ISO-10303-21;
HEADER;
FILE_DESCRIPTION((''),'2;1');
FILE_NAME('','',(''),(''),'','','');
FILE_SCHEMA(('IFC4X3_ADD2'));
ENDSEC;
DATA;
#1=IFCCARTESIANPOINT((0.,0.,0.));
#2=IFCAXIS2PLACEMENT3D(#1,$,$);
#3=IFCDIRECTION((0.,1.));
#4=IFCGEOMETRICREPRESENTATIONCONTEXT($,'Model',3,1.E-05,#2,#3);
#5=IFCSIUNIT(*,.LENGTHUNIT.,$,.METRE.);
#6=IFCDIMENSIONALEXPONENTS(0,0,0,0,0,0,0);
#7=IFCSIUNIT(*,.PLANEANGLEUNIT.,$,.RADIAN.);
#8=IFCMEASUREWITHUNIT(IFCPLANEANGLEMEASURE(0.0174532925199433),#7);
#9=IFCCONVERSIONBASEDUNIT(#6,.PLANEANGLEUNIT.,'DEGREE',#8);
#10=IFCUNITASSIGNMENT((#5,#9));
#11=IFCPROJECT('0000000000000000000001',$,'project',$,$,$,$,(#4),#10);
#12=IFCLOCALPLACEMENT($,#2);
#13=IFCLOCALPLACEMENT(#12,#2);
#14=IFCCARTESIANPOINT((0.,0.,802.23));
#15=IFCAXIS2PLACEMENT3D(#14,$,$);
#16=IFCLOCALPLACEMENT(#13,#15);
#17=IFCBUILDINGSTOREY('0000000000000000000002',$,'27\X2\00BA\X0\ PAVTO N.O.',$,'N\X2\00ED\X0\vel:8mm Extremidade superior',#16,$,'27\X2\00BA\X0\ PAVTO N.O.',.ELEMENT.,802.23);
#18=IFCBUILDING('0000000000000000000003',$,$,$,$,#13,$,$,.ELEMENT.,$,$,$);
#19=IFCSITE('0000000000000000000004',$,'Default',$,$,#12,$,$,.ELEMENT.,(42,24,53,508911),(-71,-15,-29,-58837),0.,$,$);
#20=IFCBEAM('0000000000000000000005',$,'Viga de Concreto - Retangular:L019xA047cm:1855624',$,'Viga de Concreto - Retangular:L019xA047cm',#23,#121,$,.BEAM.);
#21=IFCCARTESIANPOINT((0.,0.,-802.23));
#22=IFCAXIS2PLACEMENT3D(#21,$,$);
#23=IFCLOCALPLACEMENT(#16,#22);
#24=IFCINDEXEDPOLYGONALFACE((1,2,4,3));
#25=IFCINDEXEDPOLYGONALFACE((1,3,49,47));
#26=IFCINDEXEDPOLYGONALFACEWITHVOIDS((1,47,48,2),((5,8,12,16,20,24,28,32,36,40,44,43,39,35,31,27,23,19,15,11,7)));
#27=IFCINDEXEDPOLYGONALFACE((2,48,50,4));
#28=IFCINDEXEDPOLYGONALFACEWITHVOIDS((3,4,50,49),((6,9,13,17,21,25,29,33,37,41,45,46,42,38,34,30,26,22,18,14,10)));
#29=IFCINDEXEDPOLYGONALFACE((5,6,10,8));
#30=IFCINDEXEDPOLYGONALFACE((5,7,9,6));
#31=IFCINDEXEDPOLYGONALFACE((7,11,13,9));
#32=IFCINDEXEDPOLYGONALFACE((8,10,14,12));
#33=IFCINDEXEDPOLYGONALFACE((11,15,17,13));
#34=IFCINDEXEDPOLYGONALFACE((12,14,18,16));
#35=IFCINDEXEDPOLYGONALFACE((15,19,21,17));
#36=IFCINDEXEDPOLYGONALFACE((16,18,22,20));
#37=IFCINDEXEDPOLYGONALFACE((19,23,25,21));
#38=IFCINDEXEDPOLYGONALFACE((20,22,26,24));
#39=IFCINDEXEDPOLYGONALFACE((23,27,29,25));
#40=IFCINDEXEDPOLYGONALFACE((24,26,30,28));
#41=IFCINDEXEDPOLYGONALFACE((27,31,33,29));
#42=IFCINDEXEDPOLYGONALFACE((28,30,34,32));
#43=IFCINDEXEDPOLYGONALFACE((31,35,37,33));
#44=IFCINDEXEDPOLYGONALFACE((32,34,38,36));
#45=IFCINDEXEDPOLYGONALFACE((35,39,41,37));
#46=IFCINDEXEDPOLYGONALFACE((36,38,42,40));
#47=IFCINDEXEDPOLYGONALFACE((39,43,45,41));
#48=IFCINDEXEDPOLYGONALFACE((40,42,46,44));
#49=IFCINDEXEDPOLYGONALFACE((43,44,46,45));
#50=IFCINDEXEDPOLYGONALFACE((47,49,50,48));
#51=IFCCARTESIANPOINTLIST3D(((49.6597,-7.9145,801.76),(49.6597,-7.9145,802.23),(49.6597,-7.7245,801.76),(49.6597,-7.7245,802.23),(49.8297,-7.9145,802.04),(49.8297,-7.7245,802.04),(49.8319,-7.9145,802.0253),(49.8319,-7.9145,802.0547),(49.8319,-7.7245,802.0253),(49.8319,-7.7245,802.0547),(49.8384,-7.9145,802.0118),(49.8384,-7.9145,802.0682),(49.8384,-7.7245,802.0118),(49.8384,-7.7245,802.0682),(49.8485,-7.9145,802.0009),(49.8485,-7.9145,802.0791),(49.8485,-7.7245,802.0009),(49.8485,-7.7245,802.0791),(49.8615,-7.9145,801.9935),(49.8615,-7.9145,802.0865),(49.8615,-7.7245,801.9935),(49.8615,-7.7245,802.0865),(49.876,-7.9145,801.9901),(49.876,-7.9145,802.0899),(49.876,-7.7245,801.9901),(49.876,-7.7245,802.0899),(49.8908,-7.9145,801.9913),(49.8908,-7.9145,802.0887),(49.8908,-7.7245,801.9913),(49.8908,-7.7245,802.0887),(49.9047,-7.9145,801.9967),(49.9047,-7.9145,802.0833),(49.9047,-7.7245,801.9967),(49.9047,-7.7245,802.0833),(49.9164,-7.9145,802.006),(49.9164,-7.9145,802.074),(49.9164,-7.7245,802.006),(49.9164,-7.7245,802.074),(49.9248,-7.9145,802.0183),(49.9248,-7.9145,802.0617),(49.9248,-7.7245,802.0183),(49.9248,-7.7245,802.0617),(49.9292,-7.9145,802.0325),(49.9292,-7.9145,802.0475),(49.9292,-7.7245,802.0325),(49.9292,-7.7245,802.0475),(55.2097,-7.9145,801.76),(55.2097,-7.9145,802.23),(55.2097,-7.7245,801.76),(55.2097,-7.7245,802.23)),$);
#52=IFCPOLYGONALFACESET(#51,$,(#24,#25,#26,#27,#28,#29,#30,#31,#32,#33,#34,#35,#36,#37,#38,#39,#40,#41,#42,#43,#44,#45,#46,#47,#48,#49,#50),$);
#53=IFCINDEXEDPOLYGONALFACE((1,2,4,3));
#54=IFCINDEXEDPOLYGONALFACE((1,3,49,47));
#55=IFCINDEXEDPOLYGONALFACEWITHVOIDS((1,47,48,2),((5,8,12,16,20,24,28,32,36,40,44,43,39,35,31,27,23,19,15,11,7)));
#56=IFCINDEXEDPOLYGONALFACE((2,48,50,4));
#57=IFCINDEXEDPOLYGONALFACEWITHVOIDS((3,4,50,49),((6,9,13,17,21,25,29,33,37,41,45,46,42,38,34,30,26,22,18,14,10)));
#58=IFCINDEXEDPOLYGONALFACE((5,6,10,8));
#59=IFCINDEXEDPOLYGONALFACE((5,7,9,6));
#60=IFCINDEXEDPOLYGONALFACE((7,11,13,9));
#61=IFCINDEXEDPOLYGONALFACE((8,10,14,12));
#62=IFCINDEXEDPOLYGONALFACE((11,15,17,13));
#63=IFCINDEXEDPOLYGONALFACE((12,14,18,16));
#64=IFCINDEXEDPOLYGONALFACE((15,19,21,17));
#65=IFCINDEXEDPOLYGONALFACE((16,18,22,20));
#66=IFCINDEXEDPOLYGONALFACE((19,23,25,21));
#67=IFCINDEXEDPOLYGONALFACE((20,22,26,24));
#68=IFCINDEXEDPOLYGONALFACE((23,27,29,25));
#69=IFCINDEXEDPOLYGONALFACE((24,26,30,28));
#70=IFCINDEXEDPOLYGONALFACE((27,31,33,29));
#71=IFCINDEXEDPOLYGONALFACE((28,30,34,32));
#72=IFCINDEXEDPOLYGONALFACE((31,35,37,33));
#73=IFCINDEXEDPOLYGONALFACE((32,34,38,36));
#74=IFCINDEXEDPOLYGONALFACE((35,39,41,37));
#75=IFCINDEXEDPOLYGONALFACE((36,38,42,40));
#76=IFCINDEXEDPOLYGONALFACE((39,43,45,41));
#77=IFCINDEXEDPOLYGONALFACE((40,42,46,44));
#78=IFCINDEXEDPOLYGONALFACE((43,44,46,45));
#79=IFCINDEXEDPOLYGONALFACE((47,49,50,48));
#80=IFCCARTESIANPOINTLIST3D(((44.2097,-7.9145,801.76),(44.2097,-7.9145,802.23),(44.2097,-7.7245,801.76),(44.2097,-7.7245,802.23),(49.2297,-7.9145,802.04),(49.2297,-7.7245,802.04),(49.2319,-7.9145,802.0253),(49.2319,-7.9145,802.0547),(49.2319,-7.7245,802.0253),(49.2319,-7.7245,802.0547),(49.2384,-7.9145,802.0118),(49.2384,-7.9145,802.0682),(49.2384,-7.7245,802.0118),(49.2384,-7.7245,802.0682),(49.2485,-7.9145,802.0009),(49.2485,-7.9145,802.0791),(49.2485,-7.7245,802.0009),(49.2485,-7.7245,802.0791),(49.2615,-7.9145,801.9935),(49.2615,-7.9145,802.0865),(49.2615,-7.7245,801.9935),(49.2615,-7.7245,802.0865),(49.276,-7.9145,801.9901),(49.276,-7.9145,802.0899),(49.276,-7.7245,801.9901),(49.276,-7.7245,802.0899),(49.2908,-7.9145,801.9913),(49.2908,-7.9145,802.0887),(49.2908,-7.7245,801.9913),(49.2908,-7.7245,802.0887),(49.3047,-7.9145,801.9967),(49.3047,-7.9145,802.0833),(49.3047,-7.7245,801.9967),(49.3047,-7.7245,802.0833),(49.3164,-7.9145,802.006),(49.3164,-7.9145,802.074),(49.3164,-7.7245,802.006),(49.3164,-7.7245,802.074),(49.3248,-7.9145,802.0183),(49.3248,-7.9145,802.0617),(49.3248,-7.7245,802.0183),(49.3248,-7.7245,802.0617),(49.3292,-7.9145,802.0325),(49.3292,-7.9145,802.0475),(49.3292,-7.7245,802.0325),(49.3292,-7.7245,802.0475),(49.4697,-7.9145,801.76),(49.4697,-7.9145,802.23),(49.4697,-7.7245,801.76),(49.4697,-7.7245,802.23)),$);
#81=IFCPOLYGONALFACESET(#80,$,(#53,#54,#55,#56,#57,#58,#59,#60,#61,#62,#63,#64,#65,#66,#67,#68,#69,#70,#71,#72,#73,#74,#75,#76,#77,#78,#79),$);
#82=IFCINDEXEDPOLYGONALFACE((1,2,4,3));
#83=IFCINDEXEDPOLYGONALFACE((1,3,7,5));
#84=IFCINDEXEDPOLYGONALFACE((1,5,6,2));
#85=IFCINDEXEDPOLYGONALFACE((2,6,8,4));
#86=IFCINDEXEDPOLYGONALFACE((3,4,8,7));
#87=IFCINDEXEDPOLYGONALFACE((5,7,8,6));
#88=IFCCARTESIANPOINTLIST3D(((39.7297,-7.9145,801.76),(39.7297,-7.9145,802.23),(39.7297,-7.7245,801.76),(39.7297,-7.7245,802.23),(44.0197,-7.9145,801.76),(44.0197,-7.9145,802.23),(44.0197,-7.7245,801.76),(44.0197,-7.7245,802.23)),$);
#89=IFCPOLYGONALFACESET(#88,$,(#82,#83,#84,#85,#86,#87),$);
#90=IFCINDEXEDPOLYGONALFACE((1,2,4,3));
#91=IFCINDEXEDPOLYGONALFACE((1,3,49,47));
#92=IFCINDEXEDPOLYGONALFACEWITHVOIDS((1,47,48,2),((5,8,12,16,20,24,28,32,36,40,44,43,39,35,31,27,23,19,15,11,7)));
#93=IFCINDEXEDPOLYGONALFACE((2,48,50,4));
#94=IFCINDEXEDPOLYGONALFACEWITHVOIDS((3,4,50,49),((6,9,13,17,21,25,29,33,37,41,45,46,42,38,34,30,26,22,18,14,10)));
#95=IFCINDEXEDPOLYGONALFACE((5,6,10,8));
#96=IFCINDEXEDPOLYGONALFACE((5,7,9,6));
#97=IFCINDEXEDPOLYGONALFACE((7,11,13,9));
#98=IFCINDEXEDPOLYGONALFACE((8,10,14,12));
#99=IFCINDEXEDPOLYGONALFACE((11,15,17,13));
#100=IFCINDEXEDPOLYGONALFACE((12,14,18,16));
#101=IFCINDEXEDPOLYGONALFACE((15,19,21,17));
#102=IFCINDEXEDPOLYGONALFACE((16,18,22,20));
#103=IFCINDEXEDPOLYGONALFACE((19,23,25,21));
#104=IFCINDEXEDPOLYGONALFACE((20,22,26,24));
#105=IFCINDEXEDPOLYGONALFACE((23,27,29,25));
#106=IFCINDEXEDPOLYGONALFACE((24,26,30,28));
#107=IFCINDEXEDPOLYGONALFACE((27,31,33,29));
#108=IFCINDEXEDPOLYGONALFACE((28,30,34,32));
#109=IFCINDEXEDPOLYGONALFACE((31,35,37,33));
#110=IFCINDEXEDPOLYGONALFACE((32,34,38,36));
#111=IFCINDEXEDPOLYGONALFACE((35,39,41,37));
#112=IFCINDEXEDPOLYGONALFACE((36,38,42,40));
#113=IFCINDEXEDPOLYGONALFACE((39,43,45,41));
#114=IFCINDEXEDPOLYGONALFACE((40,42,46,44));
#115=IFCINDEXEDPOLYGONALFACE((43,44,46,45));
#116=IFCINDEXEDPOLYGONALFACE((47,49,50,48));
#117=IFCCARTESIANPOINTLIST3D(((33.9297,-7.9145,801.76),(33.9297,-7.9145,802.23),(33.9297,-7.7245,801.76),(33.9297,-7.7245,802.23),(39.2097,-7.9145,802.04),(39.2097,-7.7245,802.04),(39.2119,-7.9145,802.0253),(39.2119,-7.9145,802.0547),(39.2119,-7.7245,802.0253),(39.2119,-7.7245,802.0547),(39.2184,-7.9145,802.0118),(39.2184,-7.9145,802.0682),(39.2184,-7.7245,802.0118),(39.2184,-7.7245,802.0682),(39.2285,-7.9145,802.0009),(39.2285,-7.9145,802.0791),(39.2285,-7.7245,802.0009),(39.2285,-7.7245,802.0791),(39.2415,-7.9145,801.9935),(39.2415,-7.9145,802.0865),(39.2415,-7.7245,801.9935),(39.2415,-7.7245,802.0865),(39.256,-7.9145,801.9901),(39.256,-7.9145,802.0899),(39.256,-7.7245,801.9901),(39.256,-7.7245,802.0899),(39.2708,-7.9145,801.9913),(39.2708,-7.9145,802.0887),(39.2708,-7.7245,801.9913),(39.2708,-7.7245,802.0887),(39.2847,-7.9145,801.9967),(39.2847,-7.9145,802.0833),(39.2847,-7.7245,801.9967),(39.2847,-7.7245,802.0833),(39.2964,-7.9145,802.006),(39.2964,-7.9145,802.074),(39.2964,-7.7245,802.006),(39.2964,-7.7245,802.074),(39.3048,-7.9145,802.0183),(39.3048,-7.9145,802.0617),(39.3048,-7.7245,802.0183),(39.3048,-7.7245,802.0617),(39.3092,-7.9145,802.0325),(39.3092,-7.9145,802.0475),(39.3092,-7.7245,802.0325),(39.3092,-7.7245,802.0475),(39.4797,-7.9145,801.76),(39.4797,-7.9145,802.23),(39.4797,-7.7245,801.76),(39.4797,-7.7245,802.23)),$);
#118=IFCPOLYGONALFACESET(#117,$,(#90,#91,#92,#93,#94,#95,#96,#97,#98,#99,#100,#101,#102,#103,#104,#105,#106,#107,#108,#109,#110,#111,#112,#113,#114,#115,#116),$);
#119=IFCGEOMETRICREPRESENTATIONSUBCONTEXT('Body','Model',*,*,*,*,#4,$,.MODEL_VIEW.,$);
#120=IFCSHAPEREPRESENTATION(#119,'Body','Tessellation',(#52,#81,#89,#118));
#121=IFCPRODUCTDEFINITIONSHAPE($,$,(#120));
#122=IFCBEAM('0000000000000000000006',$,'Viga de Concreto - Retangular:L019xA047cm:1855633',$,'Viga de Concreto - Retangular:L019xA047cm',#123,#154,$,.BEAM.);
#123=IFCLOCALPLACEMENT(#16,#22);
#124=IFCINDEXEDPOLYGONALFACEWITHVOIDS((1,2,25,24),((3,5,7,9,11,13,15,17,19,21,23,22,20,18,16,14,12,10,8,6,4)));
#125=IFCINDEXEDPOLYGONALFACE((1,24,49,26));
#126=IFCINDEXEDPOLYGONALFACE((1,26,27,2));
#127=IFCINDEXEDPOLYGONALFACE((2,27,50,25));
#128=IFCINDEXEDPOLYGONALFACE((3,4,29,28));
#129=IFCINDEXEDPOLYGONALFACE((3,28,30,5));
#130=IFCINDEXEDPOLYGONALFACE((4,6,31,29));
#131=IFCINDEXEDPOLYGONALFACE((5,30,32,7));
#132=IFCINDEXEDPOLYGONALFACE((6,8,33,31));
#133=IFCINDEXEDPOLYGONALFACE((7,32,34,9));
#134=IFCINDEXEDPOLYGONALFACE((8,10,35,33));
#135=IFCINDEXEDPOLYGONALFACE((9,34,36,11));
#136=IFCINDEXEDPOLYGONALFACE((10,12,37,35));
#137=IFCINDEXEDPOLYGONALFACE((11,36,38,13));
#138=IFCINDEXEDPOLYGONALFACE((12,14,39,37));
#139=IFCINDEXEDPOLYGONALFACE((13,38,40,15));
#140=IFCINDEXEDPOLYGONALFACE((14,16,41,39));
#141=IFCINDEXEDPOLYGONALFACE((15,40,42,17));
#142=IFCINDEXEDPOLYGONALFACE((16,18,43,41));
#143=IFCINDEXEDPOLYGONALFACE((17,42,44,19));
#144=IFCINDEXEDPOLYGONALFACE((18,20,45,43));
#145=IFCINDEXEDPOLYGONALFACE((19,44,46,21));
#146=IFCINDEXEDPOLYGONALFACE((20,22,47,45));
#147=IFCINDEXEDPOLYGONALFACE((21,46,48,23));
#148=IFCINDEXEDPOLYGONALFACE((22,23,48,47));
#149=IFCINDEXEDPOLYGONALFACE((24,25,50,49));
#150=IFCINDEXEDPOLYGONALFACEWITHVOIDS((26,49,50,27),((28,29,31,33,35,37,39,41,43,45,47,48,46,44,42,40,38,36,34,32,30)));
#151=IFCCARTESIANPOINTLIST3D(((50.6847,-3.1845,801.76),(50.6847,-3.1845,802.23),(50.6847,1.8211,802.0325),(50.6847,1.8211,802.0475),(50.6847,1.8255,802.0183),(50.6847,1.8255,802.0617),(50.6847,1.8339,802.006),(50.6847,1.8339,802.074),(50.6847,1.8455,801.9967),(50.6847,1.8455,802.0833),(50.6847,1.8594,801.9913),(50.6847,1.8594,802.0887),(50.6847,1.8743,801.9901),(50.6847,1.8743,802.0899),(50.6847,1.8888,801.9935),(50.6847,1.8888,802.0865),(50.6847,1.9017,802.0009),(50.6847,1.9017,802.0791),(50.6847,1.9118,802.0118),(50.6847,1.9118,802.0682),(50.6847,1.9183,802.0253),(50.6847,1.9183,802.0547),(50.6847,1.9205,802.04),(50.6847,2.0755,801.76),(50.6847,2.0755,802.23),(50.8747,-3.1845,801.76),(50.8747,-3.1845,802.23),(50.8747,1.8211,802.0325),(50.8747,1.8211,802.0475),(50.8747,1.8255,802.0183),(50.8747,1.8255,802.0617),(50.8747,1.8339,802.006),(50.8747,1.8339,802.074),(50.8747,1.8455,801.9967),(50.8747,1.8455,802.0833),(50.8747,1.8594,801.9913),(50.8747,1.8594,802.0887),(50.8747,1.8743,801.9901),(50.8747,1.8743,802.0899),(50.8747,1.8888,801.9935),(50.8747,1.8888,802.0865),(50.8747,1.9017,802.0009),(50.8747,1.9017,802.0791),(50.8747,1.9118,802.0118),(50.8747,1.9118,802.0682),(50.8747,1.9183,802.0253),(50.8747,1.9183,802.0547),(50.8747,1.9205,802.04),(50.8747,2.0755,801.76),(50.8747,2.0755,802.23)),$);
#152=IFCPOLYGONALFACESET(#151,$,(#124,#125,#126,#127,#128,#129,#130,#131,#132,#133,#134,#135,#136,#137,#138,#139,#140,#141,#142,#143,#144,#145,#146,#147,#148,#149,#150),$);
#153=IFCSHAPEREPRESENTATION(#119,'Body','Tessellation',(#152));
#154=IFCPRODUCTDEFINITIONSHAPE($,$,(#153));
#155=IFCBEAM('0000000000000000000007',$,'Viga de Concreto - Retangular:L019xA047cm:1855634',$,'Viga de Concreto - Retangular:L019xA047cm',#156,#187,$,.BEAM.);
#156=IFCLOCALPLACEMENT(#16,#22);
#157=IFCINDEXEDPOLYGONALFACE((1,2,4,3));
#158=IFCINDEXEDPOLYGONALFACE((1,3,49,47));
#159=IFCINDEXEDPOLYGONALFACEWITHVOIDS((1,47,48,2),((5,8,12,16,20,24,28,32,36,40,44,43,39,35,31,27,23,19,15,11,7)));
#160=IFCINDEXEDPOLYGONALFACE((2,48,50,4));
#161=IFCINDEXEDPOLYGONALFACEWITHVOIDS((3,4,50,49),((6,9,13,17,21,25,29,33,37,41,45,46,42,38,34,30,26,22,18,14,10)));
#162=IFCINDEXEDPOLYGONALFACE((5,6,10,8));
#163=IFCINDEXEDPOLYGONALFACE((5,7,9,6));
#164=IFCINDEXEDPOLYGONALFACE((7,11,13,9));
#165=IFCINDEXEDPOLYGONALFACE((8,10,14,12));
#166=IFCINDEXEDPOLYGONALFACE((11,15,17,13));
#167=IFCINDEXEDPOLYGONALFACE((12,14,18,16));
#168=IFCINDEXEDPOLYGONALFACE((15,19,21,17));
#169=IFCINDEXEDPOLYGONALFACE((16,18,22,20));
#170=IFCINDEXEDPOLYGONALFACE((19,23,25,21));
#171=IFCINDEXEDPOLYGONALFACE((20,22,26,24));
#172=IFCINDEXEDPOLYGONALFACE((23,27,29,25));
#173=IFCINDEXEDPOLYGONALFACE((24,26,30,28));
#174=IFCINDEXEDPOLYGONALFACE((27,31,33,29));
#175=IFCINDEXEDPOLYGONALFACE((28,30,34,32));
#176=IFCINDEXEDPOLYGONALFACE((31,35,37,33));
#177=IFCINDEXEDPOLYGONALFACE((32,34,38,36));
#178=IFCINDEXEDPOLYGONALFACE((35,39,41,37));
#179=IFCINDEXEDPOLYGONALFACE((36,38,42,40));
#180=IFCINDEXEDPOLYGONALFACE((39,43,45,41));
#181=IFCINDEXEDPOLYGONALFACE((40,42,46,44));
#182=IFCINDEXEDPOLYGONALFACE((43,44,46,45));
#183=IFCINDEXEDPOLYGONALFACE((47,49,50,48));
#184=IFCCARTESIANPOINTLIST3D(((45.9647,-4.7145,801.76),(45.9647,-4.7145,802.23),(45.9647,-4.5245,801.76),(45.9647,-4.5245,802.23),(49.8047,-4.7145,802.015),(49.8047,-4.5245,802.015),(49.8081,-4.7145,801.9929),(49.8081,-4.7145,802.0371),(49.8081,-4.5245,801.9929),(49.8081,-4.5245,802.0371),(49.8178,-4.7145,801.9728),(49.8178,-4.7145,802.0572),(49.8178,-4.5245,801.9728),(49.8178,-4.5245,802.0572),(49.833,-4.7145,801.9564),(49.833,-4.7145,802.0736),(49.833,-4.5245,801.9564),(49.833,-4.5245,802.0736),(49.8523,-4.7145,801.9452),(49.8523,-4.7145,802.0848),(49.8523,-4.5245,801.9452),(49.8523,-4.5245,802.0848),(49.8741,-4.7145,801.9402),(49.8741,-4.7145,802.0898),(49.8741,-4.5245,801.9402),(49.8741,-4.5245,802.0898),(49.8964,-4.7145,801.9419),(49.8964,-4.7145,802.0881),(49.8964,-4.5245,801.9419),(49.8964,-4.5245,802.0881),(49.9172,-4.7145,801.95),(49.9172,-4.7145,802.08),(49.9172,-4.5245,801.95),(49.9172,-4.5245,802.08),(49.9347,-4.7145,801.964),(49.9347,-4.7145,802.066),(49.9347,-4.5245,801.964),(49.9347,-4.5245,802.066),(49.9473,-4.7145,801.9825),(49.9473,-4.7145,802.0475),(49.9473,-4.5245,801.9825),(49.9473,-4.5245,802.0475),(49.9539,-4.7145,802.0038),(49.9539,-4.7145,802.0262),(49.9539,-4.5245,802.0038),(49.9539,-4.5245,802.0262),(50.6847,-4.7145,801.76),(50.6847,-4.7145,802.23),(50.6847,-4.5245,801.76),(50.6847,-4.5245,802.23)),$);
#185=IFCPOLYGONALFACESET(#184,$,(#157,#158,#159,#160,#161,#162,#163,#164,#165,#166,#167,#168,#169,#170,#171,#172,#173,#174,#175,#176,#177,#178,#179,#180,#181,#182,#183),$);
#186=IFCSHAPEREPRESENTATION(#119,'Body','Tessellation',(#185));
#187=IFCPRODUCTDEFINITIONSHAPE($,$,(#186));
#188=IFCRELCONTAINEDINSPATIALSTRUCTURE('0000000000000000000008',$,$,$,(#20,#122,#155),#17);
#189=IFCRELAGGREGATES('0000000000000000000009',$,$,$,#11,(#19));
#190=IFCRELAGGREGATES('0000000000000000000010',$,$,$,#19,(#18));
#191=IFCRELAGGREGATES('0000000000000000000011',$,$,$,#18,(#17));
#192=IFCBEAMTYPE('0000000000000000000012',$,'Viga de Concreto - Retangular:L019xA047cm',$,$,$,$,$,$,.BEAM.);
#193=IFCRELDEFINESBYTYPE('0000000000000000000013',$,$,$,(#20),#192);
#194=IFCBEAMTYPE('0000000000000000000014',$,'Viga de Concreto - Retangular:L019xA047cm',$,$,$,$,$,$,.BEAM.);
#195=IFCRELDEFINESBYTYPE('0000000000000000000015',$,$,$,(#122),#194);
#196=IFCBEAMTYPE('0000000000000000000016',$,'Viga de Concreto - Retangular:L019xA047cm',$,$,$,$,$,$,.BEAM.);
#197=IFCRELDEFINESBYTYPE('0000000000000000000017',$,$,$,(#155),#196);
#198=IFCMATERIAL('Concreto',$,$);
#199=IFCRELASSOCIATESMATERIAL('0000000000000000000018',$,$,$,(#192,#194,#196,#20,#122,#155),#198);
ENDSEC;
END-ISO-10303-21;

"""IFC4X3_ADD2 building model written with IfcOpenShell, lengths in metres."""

from ifc_helpers import new_model, entity, si_unit, converted_unit, direction, frame, frame_2d, origin, origin_2d_with_axis, place, context, subcontext, project, spatial, rectangle, circle, extrude, boolean, source, transform, mapped, material, material_profile, profile_set, type_object, type_shapes, element, save


model = new_model("IFC4X3_ADD2")

# Units and contexts
model_context = context("Model", 3, precision=1e-05, world=origin(), true_north=direction((0.0, 1.0)))
body_context = subcontext(model_context, "Body", "Model", "MODEL_VIEW")
ifc_project = project(units=[si_unit("LENGTHUNIT", "METRE"), converted_unit("PLANEANGLEUNIT", "DEGREE", entity("IfcPlaneAngleMeasure", 0.0174532925199433), si_unit("PLANEANGLEUNIT", "RADIAN"), dimensions=[0, 0, 0, 0, 0, 0, 0])], contexts=[model_context])

# Site, building, storey
site_placement = place(None, origin())
site = spatial("IfcSite", under=ifc_project, at=site_placement, Name="Default", CompositionType="ELEMENT", RefLatitude=(42, 24, 53, 508911), RefLongitude=(-71, -15, -29, -58837), RefElevation=0.0)
building_placement = place(site_placement, origin())
building = spatial("IfcBuilding", under=site, at=building_placement, CompositionType="ELEMENT")
storey_placement = place(building_placement, frame((0.0, 0.0, 802.23)))
storey = spatial("IfcBuildingStorey", under=building, at=storey_placement, Name="27º PAVTO N.O.", ObjectType="Nível:8mm Extremidade superior", LongName="27º PAVTO N.O.", CompositionType="ELEMENT", Elevation=802.23)

# Beams
ifc_material = material(Name="Concreto")
ifc_material_profile_1 = material_profile(ifc_material, rectangle(XDim=0.47, YDim=0.19, at=frame_2d((0.0, 0.0), x_axis=(0.0, 1.0))), Name="L019xA047cm")
ifc_profile_set_1 = profile_set([ifc_material_profile_1], Name="L019xA047cm")
beam_type_1 = type_object("IfcBeamType", Name="Viga de Concreto - Retangular:L019xA047cm", PredefinedType="BEAM", material=ifc_profile_set_1)
shared_shape_1 = source(origin(), body_context, "Body", "SweptSolid", [
    boolean("DIFFERENCE", extrude(rectangle(XDim=0.47, YDim=0.19, at=frame_2d((0.0, 0.0), x_axis=(0.0, 1.0))), frame((49.6597, -7.8195, 801.995), z_axis=(1.0, 0.0, 0.0), x_axis=(0.0, 1.0, 0.0)), (0.0, 0.0, 1.0), 5.55), extrude(circle(Radius=0.05, at=frame_2d((0.0, 0.0), x_axis=(1.0, 0.0))), frame((49.8797, -7.7245, 802.04), z_axis=(0.0, -1.0, 0.0), x_axis=(-1.0, 0.0, 0.0)), (0.0, 0.0, 1.0), 0.19)),
    boolean("DIFFERENCE", extrude(rectangle(XDim=0.47, YDim=0.19, at=frame_2d((0.0, 0.0), x_axis=(0.0, 1.0))), frame((44.2097, -7.8195, 801.995), z_axis=(1.0, 0.0, 0.0), x_axis=(0.0, 1.0, 0.0)), (0.0, 0.0, 1.0), 5.26), extrude(circle(Radius=0.05, at=frame_2d((0.0, 0.0), x_axis=(1.0, 0.0))), frame((49.2797, -7.7245, 802.04), z_axis=(0.0, -1.0, 0.0), x_axis=(-1.0, 0.0, 0.0)), (0.0, 0.0, 1.0), 0.19)),
    extrude(rectangle(XDim=0.47, YDim=0.19, at=frame_2d((0.0, 0.0), x_axis=(1.0, 0.0))), frame((39.7297, -7.8195, 801.995), z_axis=(1.0, 0.0, 0.0), x_axis=(0.0, 0.0, -1.0)), (0.0, 0.0, 1.0), 4.29),
    boolean("DIFFERENCE", extrude(rectangle(XDim=0.47, YDim=0.19, at=frame_2d((0.0, 0.0), x_axis=(0.0, 1.0))), frame((33.9297, -7.8195, 801.995), z_axis=(1.0, 0.0, 0.0), x_axis=(0.0, 1.0, 0.0)), (0.0, 0.0, 1.0), 5.55), extrude(circle(Radius=0.05, at=frame_2d((0.0, 0.0), x_axis=(1.0, 0.0))), frame((39.2597, -7.7245, 802.04), z_axis=(0.0, -1.0, 0.0), x_axis=(-1.0, 0.0, 0.0)), (0.0, 0.0, 1.0), 0.19)),
])
type_shapes(beam_type_1, [shared_shape_1])
beam_1_placement = place(storey_placement, frame((0.0, 0.0, -802.23)))
element("IfcBeam", 1, at=beam_1_placement, inside=storey, type_object=beam_type_1, material=ifc_material, Name="Viga de Concreto - Retangular:L019xA047cm:1855624", ObjectType="Viga de Concreto - Retangular:L019xA047cm", PredefinedType="BEAM", context=body_context, shape_type="MappedRepresentation", body=[
    mapped(shared_shape_1, transform((0.0, 0.0, 0.0), scale=1.0)),
])
beam_type_2 = type_object("IfcBeamType", Name="Viga de Concreto - Retangular:L019xA047cm", PredefinedType="BEAM", material=ifc_profile_set_1)
shared_shape_2 = source(origin(), body_context, "Body", "CSG", [
    boolean("DIFFERENCE", extrude(rectangle(XDim=0.47, YDim=0.19, at=frame_2d((0.0, 0.0), x_axis=(0.0, 1.0))), frame((50.7797, 2.0755, 801.995), z_axis=(0.0, -1.0, 0.0), x_axis=(-1.0, 0.0, 0.0)), (0.0, 0.0, 1.0), 5.26), extrude(circle(Radius=0.05, at=origin_2d_with_axis()), frame((50.8747, 1.8705, 802.04), z_axis=(-1.0, 0.0, 0.0), x_axis=(0.0, 1.0, 0.0)), (0.0, 0.0, 1.0), 0.19)),
])
type_shapes(beam_type_2, [shared_shape_2])
beam_2_placement = place(storey_placement, frame((0.0, 0.0, -802.23)))
element("IfcBeam", 2, at=beam_2_placement, inside=storey, type_object=beam_type_2, material=ifc_material, Name="Viga de Concreto - Retangular:L019xA047cm:1855633", ObjectType="Viga de Concreto - Retangular:L019xA047cm", PredefinedType="BEAM", context=body_context, shape_type="MappedRepresentation", body=[
    mapped(shared_shape_2, transform((0.0, 0.0, 0.0), scale=1.0)),
])
beam_type_3 = type_object("IfcBeamType", Name="Viga de Concreto - Retangular:L019xA047cm", PredefinedType="BEAM", material=ifc_profile_set_1)
shared_shape_3 = source(origin(), body_context, "Body", "CSG", [
    boolean("DIFFERENCE", extrude(rectangle(XDim=0.47, YDim=0.19, at=frame_2d((0.0, 0.0), x_axis=(0.0, 1.0))), frame((45.9647, -4.6195, 801.995), z_axis=(1.0, 0.0, 0.0), x_axis=(0.0, 1.0, 0.0)), (0.0, 0.0, 1.0), 4.72), extrude(circle(Radius=0.075, at=frame_2d((0.0, 0.0), x_axis=(1.0, 0.0))), frame((49.8797, -4.5245, 802.015), z_axis=(0.0, -1.0, 0.0), x_axis=(-1.0, 0.0, 0.0)), (0.0, 0.0, 1.0), 0.19)),
])
type_shapes(beam_type_3, [shared_shape_3])
beam_3_placement = place(storey_placement, frame((0.0, 0.0, -802.23)))
element("IfcBeam", 3, at=beam_3_placement, inside=storey, type_object=beam_type_3, material=ifc_material, Name="Viga de Concreto - Retangular:L019xA047cm:1855634", ObjectType="Viga de Concreto - Retangular:L019xA047cm", PredefinedType="BEAM", context=body_context, shape_type="MappedRepresentation", body=[
    mapped(shared_shape_3, transform((0.0, 0.0, 0.0), scale=1.0)),
])

save(model, "model.ifc")
